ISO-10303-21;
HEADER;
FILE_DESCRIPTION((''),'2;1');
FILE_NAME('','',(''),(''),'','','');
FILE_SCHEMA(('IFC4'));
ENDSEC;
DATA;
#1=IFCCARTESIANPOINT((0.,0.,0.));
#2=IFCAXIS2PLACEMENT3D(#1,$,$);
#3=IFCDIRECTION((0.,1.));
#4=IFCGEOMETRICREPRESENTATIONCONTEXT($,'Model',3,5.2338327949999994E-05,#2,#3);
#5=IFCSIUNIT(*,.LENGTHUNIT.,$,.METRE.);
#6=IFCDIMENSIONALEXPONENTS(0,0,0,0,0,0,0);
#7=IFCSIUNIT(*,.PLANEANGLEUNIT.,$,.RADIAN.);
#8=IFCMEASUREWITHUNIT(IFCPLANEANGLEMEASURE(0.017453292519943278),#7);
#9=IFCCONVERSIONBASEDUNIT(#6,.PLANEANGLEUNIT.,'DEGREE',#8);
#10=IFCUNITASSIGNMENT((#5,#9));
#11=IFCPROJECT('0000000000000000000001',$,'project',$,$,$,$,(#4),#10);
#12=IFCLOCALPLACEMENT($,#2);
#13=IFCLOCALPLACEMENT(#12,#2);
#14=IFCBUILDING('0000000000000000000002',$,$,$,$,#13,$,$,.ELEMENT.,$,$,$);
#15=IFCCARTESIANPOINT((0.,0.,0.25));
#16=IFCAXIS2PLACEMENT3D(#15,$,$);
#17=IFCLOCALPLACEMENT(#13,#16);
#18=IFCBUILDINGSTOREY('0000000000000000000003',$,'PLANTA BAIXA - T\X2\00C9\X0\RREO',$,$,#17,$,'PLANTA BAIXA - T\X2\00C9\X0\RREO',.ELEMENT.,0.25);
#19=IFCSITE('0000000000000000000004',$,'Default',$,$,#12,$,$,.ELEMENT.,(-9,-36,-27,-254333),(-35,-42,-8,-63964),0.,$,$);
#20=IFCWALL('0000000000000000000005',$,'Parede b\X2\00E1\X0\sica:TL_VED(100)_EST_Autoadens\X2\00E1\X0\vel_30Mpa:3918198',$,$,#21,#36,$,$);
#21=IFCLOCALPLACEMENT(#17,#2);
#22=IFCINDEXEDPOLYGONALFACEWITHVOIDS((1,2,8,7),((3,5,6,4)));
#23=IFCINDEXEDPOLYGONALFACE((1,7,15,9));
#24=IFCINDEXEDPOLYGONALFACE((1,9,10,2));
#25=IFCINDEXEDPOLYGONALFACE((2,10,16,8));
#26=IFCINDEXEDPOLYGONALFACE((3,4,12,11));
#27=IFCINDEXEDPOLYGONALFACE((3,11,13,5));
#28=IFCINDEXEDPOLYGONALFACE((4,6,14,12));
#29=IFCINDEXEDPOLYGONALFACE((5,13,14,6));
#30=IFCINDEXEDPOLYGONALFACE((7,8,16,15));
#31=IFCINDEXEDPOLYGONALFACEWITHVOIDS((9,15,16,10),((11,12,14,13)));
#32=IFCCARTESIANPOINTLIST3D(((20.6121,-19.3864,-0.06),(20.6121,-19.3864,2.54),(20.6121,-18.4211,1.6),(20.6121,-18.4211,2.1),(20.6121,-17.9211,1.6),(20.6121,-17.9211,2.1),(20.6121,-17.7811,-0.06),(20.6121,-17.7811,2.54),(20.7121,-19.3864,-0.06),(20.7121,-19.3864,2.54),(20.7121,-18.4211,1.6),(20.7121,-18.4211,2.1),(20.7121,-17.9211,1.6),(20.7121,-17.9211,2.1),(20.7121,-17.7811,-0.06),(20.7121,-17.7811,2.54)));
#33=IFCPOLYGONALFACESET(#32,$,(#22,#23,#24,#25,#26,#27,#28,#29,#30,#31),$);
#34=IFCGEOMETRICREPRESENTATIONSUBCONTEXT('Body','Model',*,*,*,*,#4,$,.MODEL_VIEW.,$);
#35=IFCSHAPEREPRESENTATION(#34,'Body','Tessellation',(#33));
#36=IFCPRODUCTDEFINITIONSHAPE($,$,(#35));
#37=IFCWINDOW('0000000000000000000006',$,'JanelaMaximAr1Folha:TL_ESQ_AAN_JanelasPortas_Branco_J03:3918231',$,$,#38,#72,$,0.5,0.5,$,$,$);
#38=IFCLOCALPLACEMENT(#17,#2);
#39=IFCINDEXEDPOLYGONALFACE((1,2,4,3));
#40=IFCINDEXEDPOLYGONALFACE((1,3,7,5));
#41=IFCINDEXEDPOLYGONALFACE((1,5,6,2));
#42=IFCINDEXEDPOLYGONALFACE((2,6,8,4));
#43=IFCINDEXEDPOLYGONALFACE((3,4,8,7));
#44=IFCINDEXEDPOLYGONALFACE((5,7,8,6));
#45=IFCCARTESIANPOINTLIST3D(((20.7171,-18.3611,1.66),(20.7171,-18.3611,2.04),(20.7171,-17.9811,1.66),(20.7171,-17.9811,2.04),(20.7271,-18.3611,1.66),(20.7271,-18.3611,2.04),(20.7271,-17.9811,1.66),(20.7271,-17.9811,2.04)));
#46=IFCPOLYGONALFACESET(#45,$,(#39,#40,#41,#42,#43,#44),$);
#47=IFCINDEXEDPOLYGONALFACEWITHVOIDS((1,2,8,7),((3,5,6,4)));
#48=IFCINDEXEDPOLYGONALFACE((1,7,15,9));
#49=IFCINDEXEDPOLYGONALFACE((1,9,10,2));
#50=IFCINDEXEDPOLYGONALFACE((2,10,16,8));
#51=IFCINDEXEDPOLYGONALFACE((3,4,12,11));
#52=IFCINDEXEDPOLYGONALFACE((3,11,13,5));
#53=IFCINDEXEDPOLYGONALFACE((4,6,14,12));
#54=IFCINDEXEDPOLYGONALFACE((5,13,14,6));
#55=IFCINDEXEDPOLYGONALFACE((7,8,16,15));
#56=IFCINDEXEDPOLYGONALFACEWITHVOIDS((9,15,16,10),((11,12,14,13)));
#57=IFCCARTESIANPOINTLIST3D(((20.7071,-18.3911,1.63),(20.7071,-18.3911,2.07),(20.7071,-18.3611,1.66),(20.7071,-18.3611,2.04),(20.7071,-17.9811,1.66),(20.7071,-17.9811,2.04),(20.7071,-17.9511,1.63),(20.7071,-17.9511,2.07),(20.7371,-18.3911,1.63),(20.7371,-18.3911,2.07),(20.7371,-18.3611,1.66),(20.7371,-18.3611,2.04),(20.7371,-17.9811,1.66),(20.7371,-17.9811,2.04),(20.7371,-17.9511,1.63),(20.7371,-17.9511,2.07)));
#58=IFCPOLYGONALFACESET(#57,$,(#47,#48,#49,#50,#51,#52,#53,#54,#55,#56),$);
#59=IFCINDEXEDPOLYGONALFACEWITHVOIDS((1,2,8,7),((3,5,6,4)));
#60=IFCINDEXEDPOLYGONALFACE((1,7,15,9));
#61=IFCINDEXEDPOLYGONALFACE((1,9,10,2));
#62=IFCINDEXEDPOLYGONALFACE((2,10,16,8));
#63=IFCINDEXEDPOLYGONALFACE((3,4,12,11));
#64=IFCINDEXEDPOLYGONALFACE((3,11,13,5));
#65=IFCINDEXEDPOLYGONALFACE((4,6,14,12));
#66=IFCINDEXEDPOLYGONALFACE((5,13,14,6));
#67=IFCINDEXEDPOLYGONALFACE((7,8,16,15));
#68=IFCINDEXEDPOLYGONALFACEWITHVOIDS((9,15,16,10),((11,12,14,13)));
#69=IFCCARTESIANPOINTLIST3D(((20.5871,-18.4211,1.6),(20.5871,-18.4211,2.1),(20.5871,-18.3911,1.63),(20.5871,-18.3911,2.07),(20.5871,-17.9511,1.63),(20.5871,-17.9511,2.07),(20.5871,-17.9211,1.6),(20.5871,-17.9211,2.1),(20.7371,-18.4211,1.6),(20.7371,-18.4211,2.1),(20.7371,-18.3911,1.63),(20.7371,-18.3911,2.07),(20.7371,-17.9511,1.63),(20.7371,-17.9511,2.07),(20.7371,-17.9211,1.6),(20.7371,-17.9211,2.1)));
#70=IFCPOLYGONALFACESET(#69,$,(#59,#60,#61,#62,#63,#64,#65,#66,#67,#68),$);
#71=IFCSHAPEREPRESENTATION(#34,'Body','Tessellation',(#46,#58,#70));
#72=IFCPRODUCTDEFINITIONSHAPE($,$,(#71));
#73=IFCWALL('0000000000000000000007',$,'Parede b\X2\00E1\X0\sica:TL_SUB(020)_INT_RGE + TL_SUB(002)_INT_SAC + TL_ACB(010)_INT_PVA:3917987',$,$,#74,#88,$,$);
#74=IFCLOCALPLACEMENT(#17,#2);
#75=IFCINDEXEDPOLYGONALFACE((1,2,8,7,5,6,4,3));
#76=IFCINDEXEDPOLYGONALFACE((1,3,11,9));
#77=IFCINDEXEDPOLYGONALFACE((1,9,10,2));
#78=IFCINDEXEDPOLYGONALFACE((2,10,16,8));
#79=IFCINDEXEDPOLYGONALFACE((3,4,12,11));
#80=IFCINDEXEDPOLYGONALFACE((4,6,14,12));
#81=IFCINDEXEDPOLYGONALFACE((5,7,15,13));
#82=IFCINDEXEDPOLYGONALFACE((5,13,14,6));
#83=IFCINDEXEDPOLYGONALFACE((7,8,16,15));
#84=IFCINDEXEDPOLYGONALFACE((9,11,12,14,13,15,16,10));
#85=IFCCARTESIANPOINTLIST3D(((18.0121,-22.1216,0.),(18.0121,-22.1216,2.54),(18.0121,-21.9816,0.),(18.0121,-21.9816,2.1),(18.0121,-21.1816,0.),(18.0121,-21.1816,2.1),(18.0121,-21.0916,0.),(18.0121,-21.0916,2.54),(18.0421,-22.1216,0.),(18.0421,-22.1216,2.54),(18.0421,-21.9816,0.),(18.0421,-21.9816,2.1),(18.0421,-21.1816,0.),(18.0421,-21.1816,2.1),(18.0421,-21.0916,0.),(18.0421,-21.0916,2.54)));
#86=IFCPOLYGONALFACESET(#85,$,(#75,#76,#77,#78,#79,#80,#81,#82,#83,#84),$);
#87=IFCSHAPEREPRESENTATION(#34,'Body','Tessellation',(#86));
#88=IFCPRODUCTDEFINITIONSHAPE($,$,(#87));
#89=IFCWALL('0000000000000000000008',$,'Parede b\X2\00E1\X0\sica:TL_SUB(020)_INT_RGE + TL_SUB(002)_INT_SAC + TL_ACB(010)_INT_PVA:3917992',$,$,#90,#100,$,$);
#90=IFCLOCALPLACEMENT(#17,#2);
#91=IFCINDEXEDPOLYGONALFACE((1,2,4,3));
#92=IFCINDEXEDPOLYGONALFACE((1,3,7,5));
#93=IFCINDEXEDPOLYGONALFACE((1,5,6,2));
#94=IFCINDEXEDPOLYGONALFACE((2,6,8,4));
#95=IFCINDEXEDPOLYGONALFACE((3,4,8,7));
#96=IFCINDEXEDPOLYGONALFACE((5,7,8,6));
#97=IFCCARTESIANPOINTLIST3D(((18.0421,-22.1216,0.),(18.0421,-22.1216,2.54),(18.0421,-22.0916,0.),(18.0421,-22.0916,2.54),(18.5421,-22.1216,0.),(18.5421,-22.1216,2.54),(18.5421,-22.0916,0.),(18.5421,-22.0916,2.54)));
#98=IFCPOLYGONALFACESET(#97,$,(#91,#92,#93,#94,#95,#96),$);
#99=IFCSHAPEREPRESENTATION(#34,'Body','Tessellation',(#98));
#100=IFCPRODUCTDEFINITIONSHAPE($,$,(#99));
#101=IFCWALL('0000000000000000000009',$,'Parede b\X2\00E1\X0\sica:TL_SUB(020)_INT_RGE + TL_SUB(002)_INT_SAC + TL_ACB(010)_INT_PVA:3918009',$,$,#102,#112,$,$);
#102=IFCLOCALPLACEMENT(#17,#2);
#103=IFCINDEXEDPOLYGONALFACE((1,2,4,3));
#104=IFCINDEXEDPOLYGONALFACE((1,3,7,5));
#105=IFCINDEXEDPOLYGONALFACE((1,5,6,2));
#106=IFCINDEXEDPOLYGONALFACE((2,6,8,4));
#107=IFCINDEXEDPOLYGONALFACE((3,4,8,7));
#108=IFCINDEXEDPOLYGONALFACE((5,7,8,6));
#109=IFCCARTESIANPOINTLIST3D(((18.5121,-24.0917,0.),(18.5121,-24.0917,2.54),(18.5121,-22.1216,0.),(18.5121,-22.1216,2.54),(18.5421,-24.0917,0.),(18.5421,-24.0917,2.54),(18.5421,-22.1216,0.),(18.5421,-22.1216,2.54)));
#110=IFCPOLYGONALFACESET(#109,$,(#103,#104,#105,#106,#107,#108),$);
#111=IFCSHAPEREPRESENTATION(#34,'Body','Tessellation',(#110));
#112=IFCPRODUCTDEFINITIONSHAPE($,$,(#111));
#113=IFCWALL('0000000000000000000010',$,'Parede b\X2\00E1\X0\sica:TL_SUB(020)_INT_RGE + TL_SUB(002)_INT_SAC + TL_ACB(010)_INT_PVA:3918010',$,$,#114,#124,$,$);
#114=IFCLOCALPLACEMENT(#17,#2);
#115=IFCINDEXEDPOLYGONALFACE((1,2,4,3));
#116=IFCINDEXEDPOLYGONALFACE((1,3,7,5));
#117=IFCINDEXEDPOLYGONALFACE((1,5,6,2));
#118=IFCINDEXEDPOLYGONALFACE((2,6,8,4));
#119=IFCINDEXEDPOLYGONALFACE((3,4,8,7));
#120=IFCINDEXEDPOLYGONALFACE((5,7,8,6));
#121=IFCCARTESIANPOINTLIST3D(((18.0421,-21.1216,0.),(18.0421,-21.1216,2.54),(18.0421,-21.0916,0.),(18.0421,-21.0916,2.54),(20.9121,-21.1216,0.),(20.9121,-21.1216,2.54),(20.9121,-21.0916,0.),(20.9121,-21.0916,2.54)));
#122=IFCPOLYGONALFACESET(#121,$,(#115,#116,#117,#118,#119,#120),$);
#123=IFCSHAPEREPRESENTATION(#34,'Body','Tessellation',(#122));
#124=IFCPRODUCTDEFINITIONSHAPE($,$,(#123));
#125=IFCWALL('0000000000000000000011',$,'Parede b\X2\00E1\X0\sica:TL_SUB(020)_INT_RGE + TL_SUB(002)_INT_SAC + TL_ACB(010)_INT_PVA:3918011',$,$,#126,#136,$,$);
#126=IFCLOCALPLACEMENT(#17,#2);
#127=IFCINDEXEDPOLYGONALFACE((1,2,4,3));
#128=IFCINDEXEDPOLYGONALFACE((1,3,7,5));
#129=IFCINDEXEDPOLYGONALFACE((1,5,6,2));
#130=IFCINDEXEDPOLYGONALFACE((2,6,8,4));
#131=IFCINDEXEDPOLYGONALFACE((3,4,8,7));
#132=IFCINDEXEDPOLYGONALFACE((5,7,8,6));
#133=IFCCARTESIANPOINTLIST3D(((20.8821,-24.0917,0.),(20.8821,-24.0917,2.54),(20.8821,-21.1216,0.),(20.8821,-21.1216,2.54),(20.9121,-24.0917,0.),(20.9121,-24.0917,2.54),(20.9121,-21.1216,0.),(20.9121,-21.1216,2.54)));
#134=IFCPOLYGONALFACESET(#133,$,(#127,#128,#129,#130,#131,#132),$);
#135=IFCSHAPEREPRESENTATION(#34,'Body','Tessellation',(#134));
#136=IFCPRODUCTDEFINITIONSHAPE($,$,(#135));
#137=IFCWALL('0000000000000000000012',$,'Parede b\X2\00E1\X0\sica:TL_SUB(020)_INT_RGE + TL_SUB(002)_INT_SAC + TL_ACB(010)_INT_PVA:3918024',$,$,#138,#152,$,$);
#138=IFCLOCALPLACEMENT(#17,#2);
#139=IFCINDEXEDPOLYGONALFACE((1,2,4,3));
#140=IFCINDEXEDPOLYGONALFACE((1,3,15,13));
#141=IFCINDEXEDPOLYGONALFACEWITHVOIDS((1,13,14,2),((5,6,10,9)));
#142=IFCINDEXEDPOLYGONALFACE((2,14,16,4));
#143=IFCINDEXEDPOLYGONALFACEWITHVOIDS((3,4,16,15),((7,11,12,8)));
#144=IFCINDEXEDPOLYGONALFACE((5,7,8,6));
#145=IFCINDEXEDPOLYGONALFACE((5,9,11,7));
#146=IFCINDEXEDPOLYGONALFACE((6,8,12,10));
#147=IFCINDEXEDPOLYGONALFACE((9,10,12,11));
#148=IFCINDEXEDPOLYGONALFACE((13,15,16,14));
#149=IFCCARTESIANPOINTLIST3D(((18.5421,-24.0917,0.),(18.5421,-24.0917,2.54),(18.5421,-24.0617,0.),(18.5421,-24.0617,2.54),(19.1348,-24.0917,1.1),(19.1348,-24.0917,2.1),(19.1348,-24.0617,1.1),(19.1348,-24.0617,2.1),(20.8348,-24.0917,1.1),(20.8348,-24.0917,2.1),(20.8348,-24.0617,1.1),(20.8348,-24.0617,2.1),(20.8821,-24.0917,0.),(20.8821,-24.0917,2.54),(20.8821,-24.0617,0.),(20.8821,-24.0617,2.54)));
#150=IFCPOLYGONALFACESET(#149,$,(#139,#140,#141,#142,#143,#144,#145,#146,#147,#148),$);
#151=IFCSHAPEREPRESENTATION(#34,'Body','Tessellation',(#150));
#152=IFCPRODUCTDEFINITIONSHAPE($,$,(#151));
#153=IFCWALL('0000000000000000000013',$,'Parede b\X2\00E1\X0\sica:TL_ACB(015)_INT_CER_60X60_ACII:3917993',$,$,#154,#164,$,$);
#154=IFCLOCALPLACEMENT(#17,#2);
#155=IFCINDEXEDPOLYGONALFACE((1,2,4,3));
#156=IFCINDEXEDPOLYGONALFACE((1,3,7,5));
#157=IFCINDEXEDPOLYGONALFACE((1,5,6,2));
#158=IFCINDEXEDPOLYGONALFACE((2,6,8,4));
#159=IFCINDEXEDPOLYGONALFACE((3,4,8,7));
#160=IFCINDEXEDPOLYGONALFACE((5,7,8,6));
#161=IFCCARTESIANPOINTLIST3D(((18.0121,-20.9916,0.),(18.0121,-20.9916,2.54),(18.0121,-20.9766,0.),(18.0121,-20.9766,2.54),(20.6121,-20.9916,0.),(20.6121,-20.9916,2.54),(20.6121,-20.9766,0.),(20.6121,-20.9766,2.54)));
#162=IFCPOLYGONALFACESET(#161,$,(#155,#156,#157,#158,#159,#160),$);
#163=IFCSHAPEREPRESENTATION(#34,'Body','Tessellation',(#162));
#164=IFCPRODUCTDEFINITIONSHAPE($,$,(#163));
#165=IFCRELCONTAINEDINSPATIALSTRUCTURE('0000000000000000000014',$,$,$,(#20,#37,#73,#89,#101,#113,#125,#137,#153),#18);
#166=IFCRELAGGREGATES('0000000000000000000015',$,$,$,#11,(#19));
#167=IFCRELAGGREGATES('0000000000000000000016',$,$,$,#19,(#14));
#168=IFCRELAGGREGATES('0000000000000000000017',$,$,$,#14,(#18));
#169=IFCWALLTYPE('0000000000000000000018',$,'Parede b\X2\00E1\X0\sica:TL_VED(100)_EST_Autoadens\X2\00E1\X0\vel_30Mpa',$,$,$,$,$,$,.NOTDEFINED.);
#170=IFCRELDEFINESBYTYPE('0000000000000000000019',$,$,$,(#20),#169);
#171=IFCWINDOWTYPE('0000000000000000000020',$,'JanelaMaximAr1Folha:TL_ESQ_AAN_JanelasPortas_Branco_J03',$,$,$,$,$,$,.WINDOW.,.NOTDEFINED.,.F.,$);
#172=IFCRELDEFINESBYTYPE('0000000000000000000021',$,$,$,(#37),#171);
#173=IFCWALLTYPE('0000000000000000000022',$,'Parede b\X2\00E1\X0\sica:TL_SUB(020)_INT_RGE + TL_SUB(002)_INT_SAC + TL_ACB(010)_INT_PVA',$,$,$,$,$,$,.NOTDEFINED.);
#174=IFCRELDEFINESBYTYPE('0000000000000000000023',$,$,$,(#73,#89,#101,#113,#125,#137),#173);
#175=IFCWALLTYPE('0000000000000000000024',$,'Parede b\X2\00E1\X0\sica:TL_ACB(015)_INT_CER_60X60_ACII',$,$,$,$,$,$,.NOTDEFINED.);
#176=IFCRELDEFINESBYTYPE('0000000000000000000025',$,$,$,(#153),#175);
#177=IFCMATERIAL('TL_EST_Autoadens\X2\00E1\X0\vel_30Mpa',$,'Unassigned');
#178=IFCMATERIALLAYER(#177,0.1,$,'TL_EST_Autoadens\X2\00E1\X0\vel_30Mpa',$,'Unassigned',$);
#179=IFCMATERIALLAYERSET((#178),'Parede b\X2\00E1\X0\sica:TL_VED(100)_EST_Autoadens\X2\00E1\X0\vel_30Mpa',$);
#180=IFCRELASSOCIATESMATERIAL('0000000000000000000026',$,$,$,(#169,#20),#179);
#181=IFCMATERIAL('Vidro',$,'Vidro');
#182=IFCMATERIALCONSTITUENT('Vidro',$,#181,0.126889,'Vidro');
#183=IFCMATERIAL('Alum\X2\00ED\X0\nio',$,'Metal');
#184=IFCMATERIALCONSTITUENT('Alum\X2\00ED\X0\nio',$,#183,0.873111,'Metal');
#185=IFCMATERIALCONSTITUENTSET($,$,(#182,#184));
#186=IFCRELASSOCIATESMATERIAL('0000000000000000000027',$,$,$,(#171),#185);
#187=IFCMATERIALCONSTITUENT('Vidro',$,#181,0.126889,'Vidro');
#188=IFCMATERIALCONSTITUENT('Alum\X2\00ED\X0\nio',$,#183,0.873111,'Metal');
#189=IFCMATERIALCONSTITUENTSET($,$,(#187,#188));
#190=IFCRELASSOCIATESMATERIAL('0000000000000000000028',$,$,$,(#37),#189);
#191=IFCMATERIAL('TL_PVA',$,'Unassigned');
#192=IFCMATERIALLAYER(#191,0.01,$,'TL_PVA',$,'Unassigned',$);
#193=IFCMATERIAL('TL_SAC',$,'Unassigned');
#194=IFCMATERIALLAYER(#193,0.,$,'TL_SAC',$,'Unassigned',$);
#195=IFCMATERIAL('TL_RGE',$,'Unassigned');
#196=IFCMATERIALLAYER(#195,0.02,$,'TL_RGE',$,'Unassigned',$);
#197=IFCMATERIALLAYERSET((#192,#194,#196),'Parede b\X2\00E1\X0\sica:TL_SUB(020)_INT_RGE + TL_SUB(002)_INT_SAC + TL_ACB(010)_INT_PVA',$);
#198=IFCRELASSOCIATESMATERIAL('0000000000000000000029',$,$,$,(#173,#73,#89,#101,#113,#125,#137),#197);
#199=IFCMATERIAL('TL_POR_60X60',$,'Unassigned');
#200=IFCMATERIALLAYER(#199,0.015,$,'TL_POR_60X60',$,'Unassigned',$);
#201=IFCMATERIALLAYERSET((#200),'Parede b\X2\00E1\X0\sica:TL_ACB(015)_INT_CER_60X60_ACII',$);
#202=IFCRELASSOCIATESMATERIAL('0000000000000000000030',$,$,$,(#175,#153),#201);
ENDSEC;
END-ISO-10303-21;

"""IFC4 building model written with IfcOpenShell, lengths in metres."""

from ifc_helpers import new_model, entity, si_unit, converted_unit, direction, frame, frame_2d, origin, place, context, subcontext, project, spatial, polyline, rectangle, outline, extrude, source, transform, mapped, material, layer, layer_set, layer_usage, constituent, constituent_set, type_object, type_shapes, element, fill, save


model = new_model("IFC4")

# Units and contexts
model_context = context("Model", 3, precision=5.2338327949999994e-05, world=origin(), true_north=direction((0.0, 1.0)))
body_context = subcontext(model_context, "Body", "Model", "MODEL_VIEW")
ifc_project = project(units=[si_unit("LENGTHUNIT", "METRE"), converted_unit("PLANEANGLEUNIT", "DEGREE", entity("IfcPlaneAngleMeasure", 0.017453292519943278), si_unit("PLANEANGLEUNIT", "RADIAN"), dimensions=[0, 0, 0, 0, 0, 0, 0])], contexts=[model_context])

# Site, building, storey
site_placement = place(None, frame((0.0, 0.0, 0.0)))
site = spatial("IfcSite", under=ifc_project, at=site_placement, Name="Default", CompositionType="ELEMENT", RefLatitude=(-9, -36, -27, -254333), RefLongitude=(-35, -42, -8, -63964), RefElevation=0.0)
building_placement = place(site_placement, origin())
building = spatial("IfcBuilding", under=site, at=building_placement, CompositionType="ELEMENT")
storey_placement = place(building_placement, frame((0.0, 0.0, 0.25)))
storey = spatial("IfcBuildingStorey", under=building, at=storey_placement, Name="PLANTA BAIXA - TÉRREO", LongName="PLANTA BAIXA - TÉRREO", CompositionType="ELEMENT", Elevation=0.25)

# Shared definitions
ifc_material_1 = material(Name="TL_EST_Autoadensável_30Mpa", Category="Unassigned")
ifc_layer_1 = layer(ifc_material_1, 0.1, Name="TL_EST_Autoadensável_30Mpa", Category="Unassigned")
ifc_layer_set_1 = layer_set([ifc_layer_1], Name="Parede básica:TL_VED(100)_EST_Autoadensável_30Mpa")
wall_type_1 = type_object("IfcWallType", Name="Parede básica:TL_VED(100)_EST_Autoadensável_30Mpa", PredefinedType="NOTDEFINED", material=ifc_layer_set_1)

# Wall, opening, window
ifc_material_2 = material(Name="Vidro", Category="Vidro")
ifc_material_3 = material(Name="Alumínio", Category="Metal")
ifc_layer_usage_1 = layer_usage(ifc_layer_set_1, "AXIS2", "POSITIVE", -0.05)
wall_1_placement = place(storey_placement, frame((20.6621, -19.3864, -0.06), z_axis=(0.0, 0.0, 1.0), x_axis=(0.0, 1.0, 0.0)))
wall_1 = element("IfcWall", 1, at=wall_1_placement, inside=storey, type_object=wall_type_1, material=ifc_layer_usage_1, Name="Parede básica:TL_VED(100)_EST_Autoadensável_30Mpa:3918198", context=body_context, shape_type="SweptSolid", body=[
    extrude(rectangle(XDim=1.6052, YDim=0.1, at=frame_2d((0.8026, 0.0), x_axis=(-1.0, 0.0))), origin(), (0.0, 0.0, 1.0), 2.6),
])
opening_1_placement = place(wall_1_placement, frame((0.9652, -0.05, 1.66)))
opening_1 = element("IfcOpeningElement", 2, at=opening_1_placement, cuts=wall_1, PredefinedType="OPENING", context=body_context, shape_type="SweptSolid", body=[
    extrude(rectangle(XDim=0.5, YDim=0.5, at=frame_2d((0.25, 0.25), x_axis=(1.0, 0.0))), frame((0.0, 0.0, 0.0), z_axis=(0.0, 1.0, 0.0), x_axis=(0.0, 0.0, 1.0)), (0.0, 0.0, 1.0), 0.1),
])
ifc_constituent_1 = constituent(ifc_material_2, Name="Vidro", Category="Vidro", fraction=0.126889)
ifc_constituent_2 = constituent(ifc_material_3, Name="Alumínio", Category="Metal", fraction=0.873111)
ifc_constituent_set_1 = constituent_set(constituents=[ifc_constituent_1, ifc_constituent_2])
ifc_constituent_3 = constituent(ifc_material_2, Name="Vidro", Category="Vidro", fraction=0.126889)
ifc_constituent_4 = constituent(ifc_material_3, Name="Alumínio", Category="Metal", fraction=0.873111)
ifc_constituent_set_2 = constituent_set(constituents=[ifc_constituent_3, ifc_constituent_4])
window_type_1 = type_object("IfcWindowType", Name="JanelaMaximAr1Folha:TL_ESQ_AAN_JanelasPortas_Branco_J03", ParameterTakesPrecedence=False, PartitioningType="NOTDEFINED", PredefinedType="WINDOW", material=ifc_constituent_set_2)
shared_shape_1 = source(origin(), body_context, "Body", "SweptSolid", [
    extrude(rectangle(XDim=0.38, YDim=0.01, at=frame_2d((0.0, 0.0), x_axis=(1.0, 0.0))), frame((0.25, -0.01, 0.06)), (0.0, 0.0, 1.0), 0.38),
    extrude(outline(polyline([(-0.22, -0.22), (0.22, -0.22), (0.22, 0.22), (-0.22, 0.22), (-0.22, -0.22)]), holes=[polyline([(0.19, 0.19), (0.19, -0.19), (-0.19, -0.19), (-0.19, 0.19), (0.19, 0.19)])]), frame((0.25, 0.005, 0.25), z_axis=(0.0, -1.0, 0.0), x_axis=(0.0, 0.0, -1.0)), (0.0, 0.0, 1.0), 0.03),
    extrude(outline(polyline([(-0.25, -0.25), (0.25, -0.25), (0.25, 0.25), (-0.25, 0.25), (-0.25, -0.25)]), holes=[polyline([(-0.22, -0.22), (-0.22, 0.22), (0.22, 0.22), (0.22, -0.22), (-0.22, -0.22)])]), frame((0.25, 0.125, 0.25), z_axis=(0.0, -1.0, 0.0), x_axis=(0.0, 0.0, -1.0)), (0.0, 0.0, 1.0), 0.15),
])
type_shapes(window_type_1, [shared_shape_1])
window_1_placement = place(opening_1_placement, origin())
window_1 = element("IfcWindow", 3, at=window_1_placement, inside=storey, type_object=window_type_1, material=ifc_constituent_set_1, Name="JanelaMaximAr1Folha:TL_ESQ_AAN_JanelasPortas_Branco_J03:3918231", OverallHeight=0.5, OverallWidth=0.5, context=body_context, shape_type="MappedRepresentation", body=[
    mapped(shared_shape_1, transform((0.0, 0.0, 0.0), scale=1.0)),
])
fill(opening_1, window_1)

# Wall, opening
ifc_material_4 = material(Name="TL_PVA", Category="Unassigned")
ifc_layer_2 = layer(ifc_material_4, 0.01, Name="TL_PVA", Category="Unassigned")
ifc_material_5 = material(Name="TL_SAC", Category="Unassigned")
ifc_layer_3 = layer(ifc_material_5, 0.0, Name="TL_SAC", Category="Unassigned")
ifc_material_6 = material(Name="TL_RGE", Category="Unassigned")
ifc_layer_4 = layer(ifc_material_6, 0.02, Name="TL_RGE", Category="Unassigned")
ifc_layer_set_2 = layer_set([ifc_layer_2, ifc_layer_3, ifc_layer_4], Name="Parede básica:TL_SUB(020)_INT_RGE + TL_SUB(002)_INT_SAC + TL_ACB(010)_INT_PVA")
ifc_layer_usage_2 = layer_usage(ifc_layer_set_2, "AXIS2", "POSITIVE", -0.015)
wall_type_2 = type_object("IfcWallType", Name="Parede básica:TL_SUB(020)_INT_RGE + TL_SUB(002)_INT_SAC + TL_ACB(010)_INT_PVA", PredefinedType="NOTDEFINED", material=ifc_layer_set_2)
wall_2_placement = place(storey_placement, frame((18.0271, -22.1216, 0.0), z_axis=(0.0, 0.0, 1.0), x_axis=(0.0, 1.0, 0.0)))
wall_2 = element("IfcWall", 4, at=wall_2_placement, inside=storey, type_object=wall_type_2, material=ifc_layer_usage_2, Name="Parede básica:TL_SUB(020)_INT_RGE + TL_SUB(002)_INT_SAC + TL_ACB(010)_INT_PVA:3917987", context=body_context, shape_type="SweptSolid", body=[
    extrude(rectangle(XDim=1.03, YDim=0.03, at=frame_2d((0.515, 0.0), x_axis=(-1.0, 0.0))), origin(), (0.0, 0.0, 1.0), 2.54),
])
opening_2_placement = place(wall_2_placement, frame((22.1216, 18.0271, 0.0)))
element("IfcOpeningElement", 5, at=opening_2_placement, cuts=wall_2, PredefinedType="OPENING", context=body_context, shape_type="SweptSolid", body=[
    extrude(rectangle(XDim=2.1, YDim=0.8, at=frame_2d((0.0, 0.0), x_axis=(0.0, 1.0))), frame((-21.5816, -19.4361, 1.05), z_axis=(0.0, 1.0, 0.0), x_axis=(-1.0, 0.0, 0.0)), (0.0, 0.0, 1.0), 3.048),
])

# Walls
ifc_layer_usage_3 = layer_usage(ifc_layer_set_2, "AXIS2", "POSITIVE", -0.015)
wall_3_placement = place(storey_placement, frame((18.5421, -22.1066, 0.0), z_axis=(0.0, 0.0, 1.0), x_axis=(-1.0, 0.0, 0.0)))
element("IfcWall", 6, at=wall_3_placement, inside=storey, type_object=wall_type_2, material=ifc_layer_usage_3, Name="Parede básica:TL_SUB(020)_INT_RGE + TL_SUB(002)_INT_SAC + TL_ACB(010)_INT_PVA:3917992", context=body_context, shape_type="SweptSolid", body=[
    extrude(rectangle(XDim=0.5, YDim=0.03, at=frame_2d((0.25, 0.0), x_axis=(-1.0, 0.0))), origin(), (0.0, 0.0, 1.0), 2.54),
])
ifc_layer_usage_4 = layer_usage(ifc_layer_set_2, "AXIS2", "NEGATIVE", 0.015)
wall_4_placement = place(storey_placement, frame((18.5271, -22.1216, 0.0), z_axis=(0.0, 0.0, 1.0), x_axis=(0.0, -1.0, 0.0)))
element("IfcWall", 7, at=wall_4_placement, inside=storey, type_object=wall_type_2, material=ifc_layer_usage_4, Name="Parede básica:TL_SUB(020)_INT_RGE + TL_SUB(002)_INT_SAC + TL_ACB(010)_INT_PVA:3918009", context=body_context, shape_type="SweptSolid", body=[
    extrude(rectangle(XDim=1.9701, YDim=0.03, at=frame_2d((0.9851, 0.0), x_axis=(-1.0, 0.0))), origin(), (0.0, 0.0, 1.0), 2.54),
])
ifc_layer_usage_5 = layer_usage(ifc_layer_set_2, "AXIS2", "NEGATIVE", 0.015)
wall_5_placement = place(storey_placement, frame((20.9121, -21.1066, 0.0), z_axis=(0.0, 0.0, 1.0), x_axis=(-1.0, 0.0, 0.0)))
element("IfcWall", 8, at=wall_5_placement, inside=storey, type_object=wall_type_2, material=ifc_layer_usage_5, Name="Parede básica:TL_SUB(020)_INT_RGE + TL_SUB(002)_INT_SAC + TL_ACB(010)_INT_PVA:3918010", context=body_context, shape_type="SweptSolid", body=[
    extrude(rectangle(XDim=2.87, YDim=0.03, at=frame_2d((1.435, 0.0), x_axis=(-1.0, 0.0))), origin(), (0.0, 0.0, 1.0), 2.54),
])
ifc_layer_usage_6 = layer_usage(ifc_layer_set_2, "AXIS2", "NEGATIVE", 0.015)
wall_6_placement = place(storey_placement, frame((20.8971, -24.0917, 0.0), z_axis=(0.0, 0.0, 1.0), x_axis=(0.0, 1.0, 0.0)))
element("IfcWall", 9, at=wall_6_placement, inside=storey, type_object=wall_type_2, material=ifc_layer_usage_6, Name="Parede básica:TL_SUB(020)_INT_RGE + TL_SUB(002)_INT_SAC + TL_ACB(010)_INT_PVA:3918011", context=body_context, shape_type="SweptSolid", body=[
    extrude(rectangle(XDim=2.9701, YDim=0.03, at=frame_2d((1.4851, 0.0), x_axis=(-1.0, 0.0))), origin(), (0.0, 0.0, 1.0), 2.54),
])

# Wall, opening
ifc_layer_usage_7 = layer_usage(ifc_layer_set_2, "AXIS2", "NEGATIVE", 0.015)
wall_7_placement = place(storey_placement, frame((18.5421, -24.0767, 0.0)))
wall_7 = element("IfcWall", 10, at=wall_7_placement, inside=storey, type_object=wall_type_2, material=ifc_layer_usage_7, Name="Parede básica:TL_SUB(020)_INT_RGE + TL_SUB(002)_INT_SAC + TL_ACB(010)_INT_PVA:3918024", context=body_context, shape_type="SweptSolid", body=[
    extrude(rectangle(XDim=2.34, YDim=0.03, at=frame_2d((1.17, 0.0), x_axis=(-1.0, 0.0))), origin(), (0.0, 0.0, 1.0), 2.54),
])
opening_3_placement = place(wall_7_placement, frame((-18.5421, 24.0767, 1.1)))
element("IfcOpeningElement", 11, at=opening_3_placement, cuts=wall_7, PredefinedType="OPENING", context=body_context, shape_type="SweptSolid", body=[
    extrude(rectangle(XDim=1.0, YDim=1.7, at=frame_2d((0.0, 0.0), x_axis=(0.0, 1.0))), frame((19.9848, -25.6157, 0.5), z_axis=(0.0, 1.0, 0.0), x_axis=(1.0, 0.0, 0.0)), (0.0, 0.0, 1.0), 3.048),
])

# Wall
ifc_material_7 = material(Name="TL_POR_60X60", Category="Unassigned")
ifc_layer_5 = layer(ifc_material_7, 0.015, Name="TL_POR_60X60", Category="Unassigned")
ifc_layer_set_3 = layer_set([ifc_layer_5], Name="Parede básica:TL_ACB(015)_INT_CER_60X60_ACII")
ifc_layer_usage_8 = layer_usage(ifc_layer_set_3, "AXIS2", "POSITIVE", -0.0075)
wall_type_3 = type_object("IfcWallType", Name="Parede básica:TL_ACB(015)_INT_CER_60X60_ACII", PredefinedType="NOTDEFINED", material=ifc_layer_set_3)
wall_8_placement = place(storey_placement, frame((20.6121, -20.9841, 0.0), z_axis=(0.0, 0.0, 1.0), x_axis=(-1.0, 0.0, 0.0)))
element("IfcWall", 12, at=wall_8_placement, inside=storey, type_object=wall_type_3, material=ifc_layer_usage_8, Name="Parede básica:TL_ACB(015)_INT_CER_60X60_ACII:3917993", context=body_context, shape_type="SweptSolid", body=[
    extrude(rectangle(XDim=2.6, YDim=0.015, at=frame_2d((1.3, 0.0), x_axis=(-1.0, 0.0))), origin(), (0.0, 0.0, 1.0), 2.54),
])

save(model, "model.ifc")
